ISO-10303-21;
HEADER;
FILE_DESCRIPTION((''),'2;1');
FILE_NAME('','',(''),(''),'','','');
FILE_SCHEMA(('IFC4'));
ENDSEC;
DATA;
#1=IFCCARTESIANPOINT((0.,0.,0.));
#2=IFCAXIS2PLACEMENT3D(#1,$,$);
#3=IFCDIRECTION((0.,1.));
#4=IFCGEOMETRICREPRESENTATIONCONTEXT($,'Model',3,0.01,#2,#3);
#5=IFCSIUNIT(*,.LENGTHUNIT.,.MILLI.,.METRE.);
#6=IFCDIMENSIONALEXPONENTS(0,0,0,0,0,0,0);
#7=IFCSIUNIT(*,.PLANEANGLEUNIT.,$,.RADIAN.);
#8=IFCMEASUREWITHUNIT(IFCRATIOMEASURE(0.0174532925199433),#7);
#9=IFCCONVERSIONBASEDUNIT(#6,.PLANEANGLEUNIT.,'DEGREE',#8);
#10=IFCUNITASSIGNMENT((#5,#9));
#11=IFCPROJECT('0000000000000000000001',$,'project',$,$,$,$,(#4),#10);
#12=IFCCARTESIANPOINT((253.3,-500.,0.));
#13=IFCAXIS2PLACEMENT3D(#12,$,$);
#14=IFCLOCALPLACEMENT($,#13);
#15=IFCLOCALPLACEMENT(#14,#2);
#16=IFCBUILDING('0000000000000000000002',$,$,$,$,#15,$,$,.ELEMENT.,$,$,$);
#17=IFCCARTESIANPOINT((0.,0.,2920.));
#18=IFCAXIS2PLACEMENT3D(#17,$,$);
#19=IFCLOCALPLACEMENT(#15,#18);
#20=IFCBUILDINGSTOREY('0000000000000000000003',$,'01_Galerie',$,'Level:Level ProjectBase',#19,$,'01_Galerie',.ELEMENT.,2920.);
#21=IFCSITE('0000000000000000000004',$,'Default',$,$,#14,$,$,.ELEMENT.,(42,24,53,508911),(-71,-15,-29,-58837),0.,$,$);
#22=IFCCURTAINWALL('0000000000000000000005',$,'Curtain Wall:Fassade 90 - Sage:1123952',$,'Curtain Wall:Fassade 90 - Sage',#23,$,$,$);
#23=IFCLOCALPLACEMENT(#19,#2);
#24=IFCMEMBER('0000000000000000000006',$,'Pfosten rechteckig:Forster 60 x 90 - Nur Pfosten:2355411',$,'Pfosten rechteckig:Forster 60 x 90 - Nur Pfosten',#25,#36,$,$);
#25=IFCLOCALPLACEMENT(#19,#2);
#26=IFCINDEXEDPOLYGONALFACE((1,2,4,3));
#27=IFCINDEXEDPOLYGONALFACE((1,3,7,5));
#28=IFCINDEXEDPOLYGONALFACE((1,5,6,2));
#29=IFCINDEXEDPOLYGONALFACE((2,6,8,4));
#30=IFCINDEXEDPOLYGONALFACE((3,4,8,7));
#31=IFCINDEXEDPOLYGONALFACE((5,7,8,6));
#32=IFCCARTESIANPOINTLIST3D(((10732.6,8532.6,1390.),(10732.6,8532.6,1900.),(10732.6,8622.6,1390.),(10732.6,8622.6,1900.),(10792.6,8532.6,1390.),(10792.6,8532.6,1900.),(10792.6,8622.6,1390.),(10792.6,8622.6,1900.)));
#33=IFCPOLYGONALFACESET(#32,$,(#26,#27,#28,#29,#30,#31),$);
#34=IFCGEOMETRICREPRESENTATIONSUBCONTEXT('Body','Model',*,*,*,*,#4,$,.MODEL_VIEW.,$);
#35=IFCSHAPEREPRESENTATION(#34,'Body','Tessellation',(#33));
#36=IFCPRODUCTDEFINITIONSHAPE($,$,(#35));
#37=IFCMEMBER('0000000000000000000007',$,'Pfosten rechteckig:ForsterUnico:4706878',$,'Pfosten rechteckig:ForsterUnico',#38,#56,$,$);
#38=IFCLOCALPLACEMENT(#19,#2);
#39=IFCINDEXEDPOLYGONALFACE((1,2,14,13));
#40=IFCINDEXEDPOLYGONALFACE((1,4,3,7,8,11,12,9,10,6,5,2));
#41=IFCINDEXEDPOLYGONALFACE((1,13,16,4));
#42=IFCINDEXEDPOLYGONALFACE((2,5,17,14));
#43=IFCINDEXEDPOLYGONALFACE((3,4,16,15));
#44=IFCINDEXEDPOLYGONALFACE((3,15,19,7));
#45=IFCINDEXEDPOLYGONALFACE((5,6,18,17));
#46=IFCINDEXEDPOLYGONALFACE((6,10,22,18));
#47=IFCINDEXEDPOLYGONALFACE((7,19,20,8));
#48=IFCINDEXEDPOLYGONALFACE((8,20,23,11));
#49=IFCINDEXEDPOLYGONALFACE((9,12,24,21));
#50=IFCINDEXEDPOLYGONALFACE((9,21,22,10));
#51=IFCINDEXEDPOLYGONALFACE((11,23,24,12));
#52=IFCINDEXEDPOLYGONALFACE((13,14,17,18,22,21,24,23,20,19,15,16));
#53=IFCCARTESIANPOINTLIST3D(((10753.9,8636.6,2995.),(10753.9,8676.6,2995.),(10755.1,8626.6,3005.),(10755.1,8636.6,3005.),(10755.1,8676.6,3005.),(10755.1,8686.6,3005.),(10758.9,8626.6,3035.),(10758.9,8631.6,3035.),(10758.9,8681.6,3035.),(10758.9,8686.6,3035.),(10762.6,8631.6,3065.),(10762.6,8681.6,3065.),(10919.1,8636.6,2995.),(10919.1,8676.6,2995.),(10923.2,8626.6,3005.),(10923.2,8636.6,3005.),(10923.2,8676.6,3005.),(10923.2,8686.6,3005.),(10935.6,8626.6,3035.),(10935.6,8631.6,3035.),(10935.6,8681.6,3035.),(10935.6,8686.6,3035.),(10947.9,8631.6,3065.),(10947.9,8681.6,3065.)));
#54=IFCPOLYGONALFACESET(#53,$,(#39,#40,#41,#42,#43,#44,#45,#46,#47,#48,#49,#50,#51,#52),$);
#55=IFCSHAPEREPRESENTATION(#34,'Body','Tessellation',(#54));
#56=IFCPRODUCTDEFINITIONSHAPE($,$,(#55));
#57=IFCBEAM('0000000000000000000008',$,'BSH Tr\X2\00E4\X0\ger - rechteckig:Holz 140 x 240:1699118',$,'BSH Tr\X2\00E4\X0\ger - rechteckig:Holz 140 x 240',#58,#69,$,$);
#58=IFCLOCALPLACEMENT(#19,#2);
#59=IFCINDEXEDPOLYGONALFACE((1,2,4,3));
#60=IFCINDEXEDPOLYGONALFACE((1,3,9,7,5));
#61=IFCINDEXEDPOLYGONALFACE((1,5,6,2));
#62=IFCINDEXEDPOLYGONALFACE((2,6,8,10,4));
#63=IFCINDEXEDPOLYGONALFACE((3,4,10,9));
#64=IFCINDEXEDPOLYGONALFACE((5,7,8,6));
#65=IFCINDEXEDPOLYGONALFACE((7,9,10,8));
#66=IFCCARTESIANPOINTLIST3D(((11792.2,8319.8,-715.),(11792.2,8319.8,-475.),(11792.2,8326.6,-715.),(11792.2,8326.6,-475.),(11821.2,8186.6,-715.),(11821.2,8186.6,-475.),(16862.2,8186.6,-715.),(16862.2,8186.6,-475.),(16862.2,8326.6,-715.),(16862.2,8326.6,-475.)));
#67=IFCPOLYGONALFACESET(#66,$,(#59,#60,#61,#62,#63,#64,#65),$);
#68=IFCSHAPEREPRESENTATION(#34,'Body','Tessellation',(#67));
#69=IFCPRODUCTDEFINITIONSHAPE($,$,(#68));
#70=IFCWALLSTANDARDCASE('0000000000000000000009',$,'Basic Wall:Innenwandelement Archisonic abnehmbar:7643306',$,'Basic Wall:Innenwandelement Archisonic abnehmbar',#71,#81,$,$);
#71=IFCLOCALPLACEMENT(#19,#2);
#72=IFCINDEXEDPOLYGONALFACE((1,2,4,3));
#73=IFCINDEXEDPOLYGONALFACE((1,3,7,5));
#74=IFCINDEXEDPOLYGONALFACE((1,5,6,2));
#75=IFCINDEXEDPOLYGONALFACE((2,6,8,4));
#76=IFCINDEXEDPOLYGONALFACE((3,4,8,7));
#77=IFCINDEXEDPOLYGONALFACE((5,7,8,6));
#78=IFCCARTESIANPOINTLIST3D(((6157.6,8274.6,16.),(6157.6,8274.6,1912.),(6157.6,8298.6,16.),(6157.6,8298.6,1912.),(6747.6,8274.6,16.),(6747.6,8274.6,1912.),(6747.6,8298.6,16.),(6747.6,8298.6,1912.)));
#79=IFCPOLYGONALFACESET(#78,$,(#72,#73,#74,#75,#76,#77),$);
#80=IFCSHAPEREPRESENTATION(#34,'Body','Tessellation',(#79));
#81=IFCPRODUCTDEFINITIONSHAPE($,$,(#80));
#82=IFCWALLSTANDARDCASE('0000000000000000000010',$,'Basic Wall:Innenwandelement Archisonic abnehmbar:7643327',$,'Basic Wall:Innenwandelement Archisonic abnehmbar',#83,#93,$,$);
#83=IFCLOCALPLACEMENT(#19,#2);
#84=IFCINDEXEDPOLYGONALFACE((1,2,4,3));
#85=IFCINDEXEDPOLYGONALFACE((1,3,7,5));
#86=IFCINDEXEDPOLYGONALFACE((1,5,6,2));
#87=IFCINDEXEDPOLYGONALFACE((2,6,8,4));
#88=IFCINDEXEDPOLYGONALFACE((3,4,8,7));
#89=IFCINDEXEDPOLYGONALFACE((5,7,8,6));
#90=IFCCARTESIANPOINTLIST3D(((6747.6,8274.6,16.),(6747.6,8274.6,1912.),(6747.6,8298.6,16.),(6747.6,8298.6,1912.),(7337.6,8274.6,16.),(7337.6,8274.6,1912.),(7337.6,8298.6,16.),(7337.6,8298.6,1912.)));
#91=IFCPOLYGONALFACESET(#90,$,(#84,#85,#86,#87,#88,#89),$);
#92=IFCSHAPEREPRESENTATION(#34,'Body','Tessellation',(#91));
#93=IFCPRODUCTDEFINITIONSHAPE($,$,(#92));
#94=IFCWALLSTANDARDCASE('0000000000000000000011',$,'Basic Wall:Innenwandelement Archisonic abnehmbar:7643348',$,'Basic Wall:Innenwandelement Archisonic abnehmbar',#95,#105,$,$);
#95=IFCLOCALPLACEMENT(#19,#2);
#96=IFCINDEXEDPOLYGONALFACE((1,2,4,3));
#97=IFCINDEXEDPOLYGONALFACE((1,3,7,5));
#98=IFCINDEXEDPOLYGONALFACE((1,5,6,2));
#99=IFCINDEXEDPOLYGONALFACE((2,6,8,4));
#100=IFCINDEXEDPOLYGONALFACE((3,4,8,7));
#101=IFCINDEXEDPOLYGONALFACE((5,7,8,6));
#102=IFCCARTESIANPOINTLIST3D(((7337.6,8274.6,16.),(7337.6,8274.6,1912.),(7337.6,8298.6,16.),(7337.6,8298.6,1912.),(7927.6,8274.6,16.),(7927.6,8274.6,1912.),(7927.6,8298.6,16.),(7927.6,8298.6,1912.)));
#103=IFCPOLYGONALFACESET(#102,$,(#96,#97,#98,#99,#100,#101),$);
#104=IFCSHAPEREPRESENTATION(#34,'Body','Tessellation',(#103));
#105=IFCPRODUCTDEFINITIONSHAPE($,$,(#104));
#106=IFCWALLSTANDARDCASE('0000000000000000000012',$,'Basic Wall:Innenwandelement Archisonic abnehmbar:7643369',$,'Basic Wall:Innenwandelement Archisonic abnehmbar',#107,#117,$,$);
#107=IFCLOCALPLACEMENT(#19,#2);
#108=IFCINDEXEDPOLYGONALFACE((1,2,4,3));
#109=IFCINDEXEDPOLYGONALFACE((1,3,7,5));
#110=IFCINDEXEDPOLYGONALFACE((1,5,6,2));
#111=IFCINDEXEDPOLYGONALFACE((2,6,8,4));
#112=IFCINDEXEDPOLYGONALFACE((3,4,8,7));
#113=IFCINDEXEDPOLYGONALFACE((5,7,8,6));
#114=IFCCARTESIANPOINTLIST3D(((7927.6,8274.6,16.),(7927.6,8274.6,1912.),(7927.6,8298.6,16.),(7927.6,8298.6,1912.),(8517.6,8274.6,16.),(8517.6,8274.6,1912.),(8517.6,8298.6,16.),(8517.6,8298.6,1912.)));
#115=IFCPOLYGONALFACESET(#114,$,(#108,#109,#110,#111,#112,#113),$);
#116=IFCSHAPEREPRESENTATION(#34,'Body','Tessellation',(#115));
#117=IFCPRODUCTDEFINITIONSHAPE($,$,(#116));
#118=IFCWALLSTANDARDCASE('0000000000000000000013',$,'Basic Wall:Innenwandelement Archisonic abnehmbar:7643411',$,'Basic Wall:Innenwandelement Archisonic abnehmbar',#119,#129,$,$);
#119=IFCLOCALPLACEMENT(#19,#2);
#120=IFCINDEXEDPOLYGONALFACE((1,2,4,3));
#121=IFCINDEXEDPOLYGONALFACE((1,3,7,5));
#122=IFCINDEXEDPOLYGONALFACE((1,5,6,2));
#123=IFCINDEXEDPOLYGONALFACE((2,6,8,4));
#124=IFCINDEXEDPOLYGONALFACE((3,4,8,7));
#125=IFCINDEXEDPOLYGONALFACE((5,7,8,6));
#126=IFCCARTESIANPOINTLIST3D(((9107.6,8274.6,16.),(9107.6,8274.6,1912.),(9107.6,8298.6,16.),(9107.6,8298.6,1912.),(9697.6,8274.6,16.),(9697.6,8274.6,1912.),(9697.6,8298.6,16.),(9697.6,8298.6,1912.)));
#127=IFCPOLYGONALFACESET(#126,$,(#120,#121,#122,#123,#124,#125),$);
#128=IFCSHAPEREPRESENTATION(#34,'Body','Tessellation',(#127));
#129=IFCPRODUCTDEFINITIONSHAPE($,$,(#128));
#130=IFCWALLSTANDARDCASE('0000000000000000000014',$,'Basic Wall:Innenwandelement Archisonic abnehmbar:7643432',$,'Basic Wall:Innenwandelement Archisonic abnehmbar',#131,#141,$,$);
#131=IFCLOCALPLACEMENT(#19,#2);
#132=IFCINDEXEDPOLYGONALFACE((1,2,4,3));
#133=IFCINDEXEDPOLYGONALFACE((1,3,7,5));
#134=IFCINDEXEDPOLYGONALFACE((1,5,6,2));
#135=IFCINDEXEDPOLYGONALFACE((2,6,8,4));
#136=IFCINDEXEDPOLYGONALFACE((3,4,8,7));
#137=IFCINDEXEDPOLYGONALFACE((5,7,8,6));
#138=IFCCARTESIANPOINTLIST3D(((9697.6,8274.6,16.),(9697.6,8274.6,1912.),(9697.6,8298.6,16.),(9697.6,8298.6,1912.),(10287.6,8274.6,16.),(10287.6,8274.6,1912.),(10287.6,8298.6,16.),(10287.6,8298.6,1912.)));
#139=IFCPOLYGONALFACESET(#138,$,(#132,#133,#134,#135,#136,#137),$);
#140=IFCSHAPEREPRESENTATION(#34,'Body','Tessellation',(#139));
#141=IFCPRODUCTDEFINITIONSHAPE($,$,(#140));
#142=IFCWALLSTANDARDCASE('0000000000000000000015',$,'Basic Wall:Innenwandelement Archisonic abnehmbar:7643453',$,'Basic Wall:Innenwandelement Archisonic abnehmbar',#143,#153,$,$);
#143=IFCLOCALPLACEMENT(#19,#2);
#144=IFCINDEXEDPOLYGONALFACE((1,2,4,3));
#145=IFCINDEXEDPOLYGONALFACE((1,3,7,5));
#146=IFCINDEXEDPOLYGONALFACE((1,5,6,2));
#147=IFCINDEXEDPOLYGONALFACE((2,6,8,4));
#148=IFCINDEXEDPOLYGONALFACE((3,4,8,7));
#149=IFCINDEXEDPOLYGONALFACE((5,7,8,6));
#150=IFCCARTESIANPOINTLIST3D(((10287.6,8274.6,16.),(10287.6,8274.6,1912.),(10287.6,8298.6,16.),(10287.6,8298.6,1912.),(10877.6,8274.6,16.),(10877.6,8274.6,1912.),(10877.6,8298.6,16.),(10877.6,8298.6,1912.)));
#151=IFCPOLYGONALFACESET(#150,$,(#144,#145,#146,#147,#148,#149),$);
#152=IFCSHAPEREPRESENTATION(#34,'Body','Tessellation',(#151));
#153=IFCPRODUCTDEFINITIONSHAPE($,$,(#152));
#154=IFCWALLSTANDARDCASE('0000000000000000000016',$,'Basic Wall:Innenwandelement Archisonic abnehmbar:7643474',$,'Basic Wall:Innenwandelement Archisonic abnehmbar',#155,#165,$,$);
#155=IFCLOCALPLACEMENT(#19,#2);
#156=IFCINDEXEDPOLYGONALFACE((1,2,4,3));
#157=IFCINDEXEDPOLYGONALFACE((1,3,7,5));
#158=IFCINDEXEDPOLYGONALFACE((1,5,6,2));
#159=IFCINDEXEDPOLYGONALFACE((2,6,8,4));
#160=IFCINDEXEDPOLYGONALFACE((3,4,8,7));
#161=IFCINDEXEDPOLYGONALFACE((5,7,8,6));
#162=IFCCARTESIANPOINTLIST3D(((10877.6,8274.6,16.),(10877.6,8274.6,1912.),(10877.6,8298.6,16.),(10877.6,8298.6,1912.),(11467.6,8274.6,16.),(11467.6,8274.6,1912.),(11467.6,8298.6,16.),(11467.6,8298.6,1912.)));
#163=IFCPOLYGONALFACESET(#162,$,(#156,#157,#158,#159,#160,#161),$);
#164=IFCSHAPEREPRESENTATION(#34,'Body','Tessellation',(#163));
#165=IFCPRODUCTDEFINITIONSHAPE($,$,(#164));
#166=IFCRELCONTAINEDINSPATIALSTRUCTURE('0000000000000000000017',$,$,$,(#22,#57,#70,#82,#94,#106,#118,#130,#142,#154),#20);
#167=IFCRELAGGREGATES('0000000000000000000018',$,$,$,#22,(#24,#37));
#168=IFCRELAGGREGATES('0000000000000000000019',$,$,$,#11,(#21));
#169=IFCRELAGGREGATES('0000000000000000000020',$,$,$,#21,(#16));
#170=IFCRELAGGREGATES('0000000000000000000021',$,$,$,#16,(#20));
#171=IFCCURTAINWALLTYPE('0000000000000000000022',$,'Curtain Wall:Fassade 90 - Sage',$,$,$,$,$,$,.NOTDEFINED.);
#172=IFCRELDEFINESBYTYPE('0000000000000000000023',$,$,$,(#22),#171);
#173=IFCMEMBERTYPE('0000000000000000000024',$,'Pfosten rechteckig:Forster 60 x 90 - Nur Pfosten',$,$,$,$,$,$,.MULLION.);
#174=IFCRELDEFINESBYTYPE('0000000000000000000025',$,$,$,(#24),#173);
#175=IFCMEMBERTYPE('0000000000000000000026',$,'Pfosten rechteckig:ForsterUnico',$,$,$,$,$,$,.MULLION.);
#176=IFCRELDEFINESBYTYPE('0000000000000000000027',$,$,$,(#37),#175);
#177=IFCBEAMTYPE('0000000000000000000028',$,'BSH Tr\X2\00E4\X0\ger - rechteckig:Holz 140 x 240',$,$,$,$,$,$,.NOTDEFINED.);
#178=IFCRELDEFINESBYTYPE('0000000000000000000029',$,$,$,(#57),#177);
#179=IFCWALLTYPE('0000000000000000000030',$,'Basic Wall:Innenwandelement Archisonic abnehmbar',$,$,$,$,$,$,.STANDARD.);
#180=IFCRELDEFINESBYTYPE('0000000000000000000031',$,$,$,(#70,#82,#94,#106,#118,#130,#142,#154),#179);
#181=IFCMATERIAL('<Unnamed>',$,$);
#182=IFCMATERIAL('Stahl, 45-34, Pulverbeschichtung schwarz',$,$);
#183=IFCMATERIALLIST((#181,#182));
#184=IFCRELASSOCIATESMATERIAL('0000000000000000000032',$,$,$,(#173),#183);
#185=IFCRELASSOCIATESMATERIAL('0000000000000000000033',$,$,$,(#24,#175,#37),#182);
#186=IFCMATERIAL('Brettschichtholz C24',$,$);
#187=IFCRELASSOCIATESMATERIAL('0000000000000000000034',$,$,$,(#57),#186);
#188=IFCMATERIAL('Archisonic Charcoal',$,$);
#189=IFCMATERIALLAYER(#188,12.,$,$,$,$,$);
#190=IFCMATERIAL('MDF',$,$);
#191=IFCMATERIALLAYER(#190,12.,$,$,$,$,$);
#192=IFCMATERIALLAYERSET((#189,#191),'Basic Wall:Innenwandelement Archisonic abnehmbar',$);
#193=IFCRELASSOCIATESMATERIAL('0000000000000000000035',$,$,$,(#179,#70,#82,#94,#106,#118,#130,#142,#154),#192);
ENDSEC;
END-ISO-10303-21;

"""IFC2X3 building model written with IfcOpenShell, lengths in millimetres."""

from ifc_helpers import new_model, entity, si_unit, converted_unit, direction, frame, frame_2d, origin, origin_2d_with_axis, place, context, subcontext, project, spatial, polyline, rectangle, outline, extrude, clip, halfspace, source, transform, mapped, material, material_list, layer, layer_set, layer_usage, type_object, type_shapes, element, aggregate, save


model = new_model("IFC2X3")

# Units and contexts
model_context = context("Model", 3, precision=0.01, world=origin(), true_north=direction((0.0, 1.0)))
body_context = subcontext(model_context, "Body", "Model", "MODEL_VIEW")
ifc_project = project(units=[si_unit("LENGTHUNIT", "METRE", prefix="MILLI"), converted_unit("PLANEANGLEUNIT", "DEGREE", entity("IfcRatioMeasure", 0.0174532925199433), si_unit("PLANEANGLEUNIT", "RADIAN"), dimensions=[0, 0, 0, 0, 0, 0, 0])], contexts=[model_context])

# Site, building, storey
site_placement = place(None, frame((253.3, -500.0, 0.0)))
site = spatial("IfcSite", under=ifc_project, at=site_placement, Name="Default", CompositionType="ELEMENT", RefLatitude=(42, 24, 53, 508911), RefLongitude=(-71, -15, -29, -58837), RefElevation=0.0)
building_placement = place(site_placement, origin())
building = spatial("IfcBuilding", under=site, at=building_placement, CompositionType="ELEMENT")
storey_placement = place(building_placement, frame((0.0, 0.0, 2920.0)))
storey = spatial("IfcBuildingStorey", under=building, at=storey_placement, Name="01_Galerie", ObjectType="Level:Level ProjectBase", LongName="01_Galerie", CompositionType="ELEMENT", Elevation=2920.0)

# Curtain wall, members
curtain_wall_type = type_object("IfcCurtainWallType", Name="Curtain Wall:Fassade 90 - Sage", PredefinedType="NOTDEFINED")
curtain_wall_placement = place(storey_placement, frame((0.0, 0.0, -2920.0)))
curtain_wall = element("IfcCurtainWall", 1, at=curtain_wall_placement, inside=storey, type_object=curtain_wall_type, Name="Curtain Wall:Fassade 90 - Sage:1123952", ObjectType="Curtain Wall:Fassade 90 - Sage")
ifc_material_1 = material(Name="Stahl, 45-34, Pulverbeschichtung schwarz")
ifc_material_2 = material(Name="<Unnamed>")
ifc_material_list_1 = material_list([ifc_material_2, ifc_material_1])
member_type_1 = type_object("IfcMemberType", Name="Pfosten rechteckig:Forster 60 x 90 - Nur Pfosten", PredefinedType="MULLION", material=ifc_material_list_1)
shared_shape_1 = source(origin(), body_context, "Body", "SweptSolid", [
    extrude(rectangle(XDim=90.0, YDim=60.0, at=origin_2d_with_axis()), frame((0.0, 79.0, -510.0), z_axis=(0.0, 0.0, 1.0), x_axis=(0.0, -1.0, 0.0)), (0.0, 0.0, 1.0), 510.0),
])
type_shapes(member_type_1, [shared_shape_1])
member_1_placement = place(storey_placement, frame((10762.6, 8656.6, 1390.0), z_axis=(0.0, 0.0, -1.0), x_axis=(1.0, 0.0, 0.0)))
member_1 = element("IfcMember", 2, at=member_1_placement, type_object=member_type_1, material=ifc_material_1, Name="Pfosten rechteckig:Forster 60 x 90 - Nur Pfosten:2355411", ObjectType="Pfosten rechteckig:Forster 60 x 90 - Nur Pfosten", context=body_context, shape_type="MappedRepresentation", body=[
    mapped(shared_shape_1, transform((0.0, 0.0, 0.0), scale=1.0)),
])
member_type_2 = type_object("IfcMemberType", Name="Pfosten rechteckig:ForsterUnico", PredefinedType="MULLION", material=ifc_material_1)
shared_shape_2 = source(origin(), body_context, "Body", "Clipping", [
    clip(clip(extrude(outline(polyline([(-20.0, -28.3), (20.0, -28.3), (20.0, -18.3), (30.0, -18.3), (30.0, 11.7), (25.0, 11.7), (25.0, 41.7), (-25.0, 41.7), (-25.0, 11.7), (-30.0, 11.7), (-30.0, -18.3), (-20.0, -18.3), (-20.0, -28.3)])), frame((-41.7, 0.0, -194.0), z_axis=(0.0, 0.0, 1.0), x_axis=(0.0, -1.0, 0.0)), (0.0, 0.0, 1.0), 194.0), halfspace(frame((0.0, 304.8, -185.4), z_axis=(0.122798, 0.0, -0.992432), x_axis=(0.992432, 0.0, 0.122798)), False)), halfspace(frame((0.0, -304.8, 0.0), z_axis=(-0.381238, 0.0, 0.924477), x_axis=(-0.924477, 0.0, -0.381238)), False)),
])
type_shapes(member_type_2, [shared_shape_2])
member_2_placement = place(storey_placement, frame((10947.9, 8656.6, 3065.0), z_axis=(1.0, 0.0, 0.0), x_axis=(0.0, 0.0, 1.0)))
member_2 = element("IfcMember", 3, at=member_2_placement, type_object=member_type_2, material=ifc_material_1, Name="Pfosten rechteckig:ForsterUnico:4706878", ObjectType="Pfosten rechteckig:ForsterUnico", context=body_context, shape_type="MappedRepresentation", body=[
    mapped(shared_shape_2, transform((0.0, 0.0, 0.0), scale=1.0)),
])
aggregate(curtain_wall, [member_1, member_2])

# Beam
ifc_material_3 = material(Name="Brettschichtholz C24")
beam_type = type_object("IfcBeamType", Name="BSH Träger - rechteckig:Holz 140 x 240", PredefinedType="NOTDEFINED")
beam_placement = place(storey_placement, frame((11792.2, 8256.6, -475.0)))
element("IfcBeam", 4, at=beam_placement, inside=storey, type_object=beam_type, material=ifc_material_3, Name="BSH Träger - rechteckig:Holz 140 x 240:1699118", ObjectType="BSH Träger - rechteckig:Holz 140 x 240", context=body_context, shape_type="Clipping", body=[
    clip(extrude(rectangle(XDim=240.0, YDim=140.0, at=frame_2d((0.0, 0.0), x_axis=(1.0, 0.0))), frame((0.0, 0.0, -120.0), z_axis=(1.0, 0.0, 0.0), x_axis=(0.0, 0.0, -1.0)), (0.0, 0.0, 1.0), 5070.0), halfspace(frame((1180.2, -5345.3, -2985.0), z_axis=(-0.977008, -0.213201, 0.0), x_axis=(-0.213201, 0.977008, 0.0)), False)),
])

# Walls
ifc_material_4 = material(Name="Archisonic Charcoal")
ifc_layer_1 = layer(ifc_material_4, 12.0)
ifc_material_5 = material(Name="MDF")
ifc_layer_2 = layer(ifc_material_5, 12.0)
ifc_layer_set_1 = layer_set([ifc_layer_1, ifc_layer_2], Name="Basic Wall:Innenwandelement Archisonic abnehmbar")
ifc_layer_usage_1 = layer_usage(ifc_layer_set_1, "AXIS2", "NEGATIVE", 12.0)
wall_type_1 = type_object("IfcWallType", Name="Basic Wall:Innenwandelement Archisonic abnehmbar", PredefinedType="STANDARD", material=ifc_layer_set_1)
wall_1_placement = place(storey_placement, frame((6747.6, 8286.6, 16.0), z_axis=(0.0, 0.0, 1.0), x_axis=(-1.0, 0.0, 0.0)))
element("IfcWallStandardCase", 5, at=wall_1_placement, inside=storey, type_object=wall_type_1, material=ifc_layer_usage_1, Name="Basic Wall:Innenwandelement Archisonic abnehmbar:7643306", ObjectType="Basic Wall:Innenwandelement Archisonic abnehmbar", context=body_context, shape_type="SweptSolid", body=[
    extrude(rectangle(XDim=590.0, YDim=24.0, at=frame_2d((295.0, 0.0), x_axis=(-1.0, 0.0))), origin(), (0.0, 0.0, 1.0), 1896.0),
])
ifc_layer_usage_2 = layer_usage(ifc_layer_set_1, "AXIS2", "NEGATIVE", 12.0)
wall_2_placement = place(storey_placement, frame((7337.6, 8286.6, 16.0), z_axis=(0.0, 0.0, 1.0), x_axis=(-1.0, 0.0, 0.0)))
element("IfcWallStandardCase", 6, at=wall_2_placement, inside=storey, type_object=wall_type_1, material=ifc_layer_usage_2, Name="Basic Wall:Innenwandelement Archisonic abnehmbar:7643327", ObjectType="Basic Wall:Innenwandelement Archisonic abnehmbar", context=body_context, shape_type="SweptSolid", body=[
    extrude(rectangle(XDim=590.0, YDim=24.0, at=frame_2d((295.0, 0.0), x_axis=(-1.0, 0.0))), origin(), (0.0, 0.0, 1.0), 1896.0),
])
ifc_layer_usage_3 = layer_usage(ifc_layer_set_1, "AXIS2", "NEGATIVE", 12.0)
wall_3_placement = place(storey_placement, frame((7927.6, 8286.6, 16.0), z_axis=(0.0, 0.0, 1.0), x_axis=(-1.0, 0.0, 0.0)))
element("IfcWallStandardCase", 7, at=wall_3_placement, inside=storey, type_object=wall_type_1, material=ifc_layer_usage_3, Name="Basic Wall:Innenwandelement Archisonic abnehmbar:7643348", ObjectType="Basic Wall:Innenwandelement Archisonic abnehmbar", context=body_context, shape_type="SweptSolid", body=[
    extrude(rectangle(XDim=590.0, YDim=24.0, at=frame_2d((295.0, 0.0), x_axis=(-1.0, 0.0))), origin(), (0.0, 0.0, 1.0), 1896.0),
])
ifc_layer_usage_4 = layer_usage(ifc_layer_set_1, "AXIS2", "NEGATIVE", 12.0)
wall_4_placement = place(storey_placement, frame((8517.6, 8286.6, 16.0), z_axis=(0.0, 0.0, 1.0), x_axis=(-1.0, 0.0, 0.0)))
element("IfcWallStandardCase", 8, at=wall_4_placement, inside=storey, type_object=wall_type_1, material=ifc_layer_usage_4, Name="Basic Wall:Innenwandelement Archisonic abnehmbar:7643369", ObjectType="Basic Wall:Innenwandelement Archisonic abnehmbar", context=body_context, shape_type="SweptSolid", body=[
    extrude(rectangle(XDim=590.0, YDim=24.0, at=frame_2d((295.0, 0.0), x_axis=(-1.0, 0.0))), origin(), (0.0, 0.0, 1.0), 1896.0),
])
ifc_layer_usage_5 = layer_usage(ifc_layer_set_1, "AXIS2", "NEGATIVE", 12.0)
wall_5_placement = place(storey_placement, frame((9697.6, 8286.6, 16.0), z_axis=(0.0, 0.0, 1.0), x_axis=(-1.0, 0.0, 0.0)))
element("IfcWallStandardCase", 9, at=wall_5_placement, inside=storey, type_object=wall_type_1, material=ifc_layer_usage_5, Name="Basic Wall:Innenwandelement Archisonic abnehmbar:7643411", ObjectType="Basic Wall:Innenwandelement Archisonic abnehmbar", context=body_context, shape_type="SweptSolid", body=[
    extrude(rectangle(XDim=590.0, YDim=24.0, at=frame_2d((295.0, 0.0), x_axis=(-1.0, 0.0))), origin(), (0.0, 0.0, 1.0), 1896.0),
])
ifc_layer_usage_6 = layer_usage(ifc_layer_set_1, "AXIS2", "NEGATIVE", 12.0)
wall_6_placement = place(storey_placement, frame((10287.6, 8286.6, 16.0), z_axis=(0.0, 0.0, 1.0), x_axis=(-1.0, 0.0, 0.0)))
element("IfcWallStandardCase", 10, at=wall_6_placement, inside=storey, type_object=wall_type_1, material=ifc_layer_usage_6, Name="Basic Wall:Innenwandelement Archisonic abnehmbar:7643432", ObjectType="Basic Wall:Innenwandelement Archisonic abnehmbar", context=body_context, shape_type="SweptSolid", body=[
    extrude(rectangle(XDim=590.0, YDim=24.0, at=frame_2d((295.0, 0.0), x_axis=(-1.0, 0.0))), origin(), (0.0, 0.0, 1.0), 1896.0),
])
ifc_layer_usage_7 = layer_usage(ifc_layer_set_1, "AXIS2", "NEGATIVE", 12.0)
wall_7_placement = place(storey_placement, frame((10877.6, 8286.6, 16.0), z_axis=(0.0, 0.0, 1.0), x_axis=(-1.0, 0.0, 0.0)))
element("IfcWallStandardCase", 11, at=wall_7_placement, inside=storey, type_object=wall_type_1, material=ifc_layer_usage_7, Name="Basic Wall:Innenwandelement Archisonic abnehmbar:7643453", ObjectType="Basic Wall:Innenwandelement Archisonic abnehmbar", context=body_context, shape_type="SweptSolid", body=[
    extrude(rectangle(XDim=590.0, YDim=24.0, at=frame_2d((295.0, 0.0), x_axis=(-1.0, 0.0))), origin(), (0.0, 0.0, 1.0), 1896.0),
])
ifc_layer_usage_8 = layer_usage(ifc_layer_set_1, "AXIS2", "NEGATIVE", 12.0)
wall_8_placement = place(storey_placement, frame((11467.6, 8286.6, 16.0), z_axis=(0.0, 0.0, 1.0), x_axis=(-1.0, 0.0, 0.0)))
element("IfcWallStandardCase", 12, at=wall_8_placement, inside=storey, type_object=wall_type_1, material=ifc_layer_usage_8, Name="Basic Wall:Innenwandelement Archisonic abnehmbar:7643474", ObjectType="Basic Wall:Innenwandelement Archisonic abnehmbar", context=body_context, shape_type="SweptSolid", body=[
    extrude(rectangle(XDim=590.0, YDim=24.0, at=frame_2d((295.0, 0.0), x_axis=(-1.0, 0.0))), origin(), (0.0, 0.0, 1.0), 1896.0),
])

save(model, "model.ifc")
